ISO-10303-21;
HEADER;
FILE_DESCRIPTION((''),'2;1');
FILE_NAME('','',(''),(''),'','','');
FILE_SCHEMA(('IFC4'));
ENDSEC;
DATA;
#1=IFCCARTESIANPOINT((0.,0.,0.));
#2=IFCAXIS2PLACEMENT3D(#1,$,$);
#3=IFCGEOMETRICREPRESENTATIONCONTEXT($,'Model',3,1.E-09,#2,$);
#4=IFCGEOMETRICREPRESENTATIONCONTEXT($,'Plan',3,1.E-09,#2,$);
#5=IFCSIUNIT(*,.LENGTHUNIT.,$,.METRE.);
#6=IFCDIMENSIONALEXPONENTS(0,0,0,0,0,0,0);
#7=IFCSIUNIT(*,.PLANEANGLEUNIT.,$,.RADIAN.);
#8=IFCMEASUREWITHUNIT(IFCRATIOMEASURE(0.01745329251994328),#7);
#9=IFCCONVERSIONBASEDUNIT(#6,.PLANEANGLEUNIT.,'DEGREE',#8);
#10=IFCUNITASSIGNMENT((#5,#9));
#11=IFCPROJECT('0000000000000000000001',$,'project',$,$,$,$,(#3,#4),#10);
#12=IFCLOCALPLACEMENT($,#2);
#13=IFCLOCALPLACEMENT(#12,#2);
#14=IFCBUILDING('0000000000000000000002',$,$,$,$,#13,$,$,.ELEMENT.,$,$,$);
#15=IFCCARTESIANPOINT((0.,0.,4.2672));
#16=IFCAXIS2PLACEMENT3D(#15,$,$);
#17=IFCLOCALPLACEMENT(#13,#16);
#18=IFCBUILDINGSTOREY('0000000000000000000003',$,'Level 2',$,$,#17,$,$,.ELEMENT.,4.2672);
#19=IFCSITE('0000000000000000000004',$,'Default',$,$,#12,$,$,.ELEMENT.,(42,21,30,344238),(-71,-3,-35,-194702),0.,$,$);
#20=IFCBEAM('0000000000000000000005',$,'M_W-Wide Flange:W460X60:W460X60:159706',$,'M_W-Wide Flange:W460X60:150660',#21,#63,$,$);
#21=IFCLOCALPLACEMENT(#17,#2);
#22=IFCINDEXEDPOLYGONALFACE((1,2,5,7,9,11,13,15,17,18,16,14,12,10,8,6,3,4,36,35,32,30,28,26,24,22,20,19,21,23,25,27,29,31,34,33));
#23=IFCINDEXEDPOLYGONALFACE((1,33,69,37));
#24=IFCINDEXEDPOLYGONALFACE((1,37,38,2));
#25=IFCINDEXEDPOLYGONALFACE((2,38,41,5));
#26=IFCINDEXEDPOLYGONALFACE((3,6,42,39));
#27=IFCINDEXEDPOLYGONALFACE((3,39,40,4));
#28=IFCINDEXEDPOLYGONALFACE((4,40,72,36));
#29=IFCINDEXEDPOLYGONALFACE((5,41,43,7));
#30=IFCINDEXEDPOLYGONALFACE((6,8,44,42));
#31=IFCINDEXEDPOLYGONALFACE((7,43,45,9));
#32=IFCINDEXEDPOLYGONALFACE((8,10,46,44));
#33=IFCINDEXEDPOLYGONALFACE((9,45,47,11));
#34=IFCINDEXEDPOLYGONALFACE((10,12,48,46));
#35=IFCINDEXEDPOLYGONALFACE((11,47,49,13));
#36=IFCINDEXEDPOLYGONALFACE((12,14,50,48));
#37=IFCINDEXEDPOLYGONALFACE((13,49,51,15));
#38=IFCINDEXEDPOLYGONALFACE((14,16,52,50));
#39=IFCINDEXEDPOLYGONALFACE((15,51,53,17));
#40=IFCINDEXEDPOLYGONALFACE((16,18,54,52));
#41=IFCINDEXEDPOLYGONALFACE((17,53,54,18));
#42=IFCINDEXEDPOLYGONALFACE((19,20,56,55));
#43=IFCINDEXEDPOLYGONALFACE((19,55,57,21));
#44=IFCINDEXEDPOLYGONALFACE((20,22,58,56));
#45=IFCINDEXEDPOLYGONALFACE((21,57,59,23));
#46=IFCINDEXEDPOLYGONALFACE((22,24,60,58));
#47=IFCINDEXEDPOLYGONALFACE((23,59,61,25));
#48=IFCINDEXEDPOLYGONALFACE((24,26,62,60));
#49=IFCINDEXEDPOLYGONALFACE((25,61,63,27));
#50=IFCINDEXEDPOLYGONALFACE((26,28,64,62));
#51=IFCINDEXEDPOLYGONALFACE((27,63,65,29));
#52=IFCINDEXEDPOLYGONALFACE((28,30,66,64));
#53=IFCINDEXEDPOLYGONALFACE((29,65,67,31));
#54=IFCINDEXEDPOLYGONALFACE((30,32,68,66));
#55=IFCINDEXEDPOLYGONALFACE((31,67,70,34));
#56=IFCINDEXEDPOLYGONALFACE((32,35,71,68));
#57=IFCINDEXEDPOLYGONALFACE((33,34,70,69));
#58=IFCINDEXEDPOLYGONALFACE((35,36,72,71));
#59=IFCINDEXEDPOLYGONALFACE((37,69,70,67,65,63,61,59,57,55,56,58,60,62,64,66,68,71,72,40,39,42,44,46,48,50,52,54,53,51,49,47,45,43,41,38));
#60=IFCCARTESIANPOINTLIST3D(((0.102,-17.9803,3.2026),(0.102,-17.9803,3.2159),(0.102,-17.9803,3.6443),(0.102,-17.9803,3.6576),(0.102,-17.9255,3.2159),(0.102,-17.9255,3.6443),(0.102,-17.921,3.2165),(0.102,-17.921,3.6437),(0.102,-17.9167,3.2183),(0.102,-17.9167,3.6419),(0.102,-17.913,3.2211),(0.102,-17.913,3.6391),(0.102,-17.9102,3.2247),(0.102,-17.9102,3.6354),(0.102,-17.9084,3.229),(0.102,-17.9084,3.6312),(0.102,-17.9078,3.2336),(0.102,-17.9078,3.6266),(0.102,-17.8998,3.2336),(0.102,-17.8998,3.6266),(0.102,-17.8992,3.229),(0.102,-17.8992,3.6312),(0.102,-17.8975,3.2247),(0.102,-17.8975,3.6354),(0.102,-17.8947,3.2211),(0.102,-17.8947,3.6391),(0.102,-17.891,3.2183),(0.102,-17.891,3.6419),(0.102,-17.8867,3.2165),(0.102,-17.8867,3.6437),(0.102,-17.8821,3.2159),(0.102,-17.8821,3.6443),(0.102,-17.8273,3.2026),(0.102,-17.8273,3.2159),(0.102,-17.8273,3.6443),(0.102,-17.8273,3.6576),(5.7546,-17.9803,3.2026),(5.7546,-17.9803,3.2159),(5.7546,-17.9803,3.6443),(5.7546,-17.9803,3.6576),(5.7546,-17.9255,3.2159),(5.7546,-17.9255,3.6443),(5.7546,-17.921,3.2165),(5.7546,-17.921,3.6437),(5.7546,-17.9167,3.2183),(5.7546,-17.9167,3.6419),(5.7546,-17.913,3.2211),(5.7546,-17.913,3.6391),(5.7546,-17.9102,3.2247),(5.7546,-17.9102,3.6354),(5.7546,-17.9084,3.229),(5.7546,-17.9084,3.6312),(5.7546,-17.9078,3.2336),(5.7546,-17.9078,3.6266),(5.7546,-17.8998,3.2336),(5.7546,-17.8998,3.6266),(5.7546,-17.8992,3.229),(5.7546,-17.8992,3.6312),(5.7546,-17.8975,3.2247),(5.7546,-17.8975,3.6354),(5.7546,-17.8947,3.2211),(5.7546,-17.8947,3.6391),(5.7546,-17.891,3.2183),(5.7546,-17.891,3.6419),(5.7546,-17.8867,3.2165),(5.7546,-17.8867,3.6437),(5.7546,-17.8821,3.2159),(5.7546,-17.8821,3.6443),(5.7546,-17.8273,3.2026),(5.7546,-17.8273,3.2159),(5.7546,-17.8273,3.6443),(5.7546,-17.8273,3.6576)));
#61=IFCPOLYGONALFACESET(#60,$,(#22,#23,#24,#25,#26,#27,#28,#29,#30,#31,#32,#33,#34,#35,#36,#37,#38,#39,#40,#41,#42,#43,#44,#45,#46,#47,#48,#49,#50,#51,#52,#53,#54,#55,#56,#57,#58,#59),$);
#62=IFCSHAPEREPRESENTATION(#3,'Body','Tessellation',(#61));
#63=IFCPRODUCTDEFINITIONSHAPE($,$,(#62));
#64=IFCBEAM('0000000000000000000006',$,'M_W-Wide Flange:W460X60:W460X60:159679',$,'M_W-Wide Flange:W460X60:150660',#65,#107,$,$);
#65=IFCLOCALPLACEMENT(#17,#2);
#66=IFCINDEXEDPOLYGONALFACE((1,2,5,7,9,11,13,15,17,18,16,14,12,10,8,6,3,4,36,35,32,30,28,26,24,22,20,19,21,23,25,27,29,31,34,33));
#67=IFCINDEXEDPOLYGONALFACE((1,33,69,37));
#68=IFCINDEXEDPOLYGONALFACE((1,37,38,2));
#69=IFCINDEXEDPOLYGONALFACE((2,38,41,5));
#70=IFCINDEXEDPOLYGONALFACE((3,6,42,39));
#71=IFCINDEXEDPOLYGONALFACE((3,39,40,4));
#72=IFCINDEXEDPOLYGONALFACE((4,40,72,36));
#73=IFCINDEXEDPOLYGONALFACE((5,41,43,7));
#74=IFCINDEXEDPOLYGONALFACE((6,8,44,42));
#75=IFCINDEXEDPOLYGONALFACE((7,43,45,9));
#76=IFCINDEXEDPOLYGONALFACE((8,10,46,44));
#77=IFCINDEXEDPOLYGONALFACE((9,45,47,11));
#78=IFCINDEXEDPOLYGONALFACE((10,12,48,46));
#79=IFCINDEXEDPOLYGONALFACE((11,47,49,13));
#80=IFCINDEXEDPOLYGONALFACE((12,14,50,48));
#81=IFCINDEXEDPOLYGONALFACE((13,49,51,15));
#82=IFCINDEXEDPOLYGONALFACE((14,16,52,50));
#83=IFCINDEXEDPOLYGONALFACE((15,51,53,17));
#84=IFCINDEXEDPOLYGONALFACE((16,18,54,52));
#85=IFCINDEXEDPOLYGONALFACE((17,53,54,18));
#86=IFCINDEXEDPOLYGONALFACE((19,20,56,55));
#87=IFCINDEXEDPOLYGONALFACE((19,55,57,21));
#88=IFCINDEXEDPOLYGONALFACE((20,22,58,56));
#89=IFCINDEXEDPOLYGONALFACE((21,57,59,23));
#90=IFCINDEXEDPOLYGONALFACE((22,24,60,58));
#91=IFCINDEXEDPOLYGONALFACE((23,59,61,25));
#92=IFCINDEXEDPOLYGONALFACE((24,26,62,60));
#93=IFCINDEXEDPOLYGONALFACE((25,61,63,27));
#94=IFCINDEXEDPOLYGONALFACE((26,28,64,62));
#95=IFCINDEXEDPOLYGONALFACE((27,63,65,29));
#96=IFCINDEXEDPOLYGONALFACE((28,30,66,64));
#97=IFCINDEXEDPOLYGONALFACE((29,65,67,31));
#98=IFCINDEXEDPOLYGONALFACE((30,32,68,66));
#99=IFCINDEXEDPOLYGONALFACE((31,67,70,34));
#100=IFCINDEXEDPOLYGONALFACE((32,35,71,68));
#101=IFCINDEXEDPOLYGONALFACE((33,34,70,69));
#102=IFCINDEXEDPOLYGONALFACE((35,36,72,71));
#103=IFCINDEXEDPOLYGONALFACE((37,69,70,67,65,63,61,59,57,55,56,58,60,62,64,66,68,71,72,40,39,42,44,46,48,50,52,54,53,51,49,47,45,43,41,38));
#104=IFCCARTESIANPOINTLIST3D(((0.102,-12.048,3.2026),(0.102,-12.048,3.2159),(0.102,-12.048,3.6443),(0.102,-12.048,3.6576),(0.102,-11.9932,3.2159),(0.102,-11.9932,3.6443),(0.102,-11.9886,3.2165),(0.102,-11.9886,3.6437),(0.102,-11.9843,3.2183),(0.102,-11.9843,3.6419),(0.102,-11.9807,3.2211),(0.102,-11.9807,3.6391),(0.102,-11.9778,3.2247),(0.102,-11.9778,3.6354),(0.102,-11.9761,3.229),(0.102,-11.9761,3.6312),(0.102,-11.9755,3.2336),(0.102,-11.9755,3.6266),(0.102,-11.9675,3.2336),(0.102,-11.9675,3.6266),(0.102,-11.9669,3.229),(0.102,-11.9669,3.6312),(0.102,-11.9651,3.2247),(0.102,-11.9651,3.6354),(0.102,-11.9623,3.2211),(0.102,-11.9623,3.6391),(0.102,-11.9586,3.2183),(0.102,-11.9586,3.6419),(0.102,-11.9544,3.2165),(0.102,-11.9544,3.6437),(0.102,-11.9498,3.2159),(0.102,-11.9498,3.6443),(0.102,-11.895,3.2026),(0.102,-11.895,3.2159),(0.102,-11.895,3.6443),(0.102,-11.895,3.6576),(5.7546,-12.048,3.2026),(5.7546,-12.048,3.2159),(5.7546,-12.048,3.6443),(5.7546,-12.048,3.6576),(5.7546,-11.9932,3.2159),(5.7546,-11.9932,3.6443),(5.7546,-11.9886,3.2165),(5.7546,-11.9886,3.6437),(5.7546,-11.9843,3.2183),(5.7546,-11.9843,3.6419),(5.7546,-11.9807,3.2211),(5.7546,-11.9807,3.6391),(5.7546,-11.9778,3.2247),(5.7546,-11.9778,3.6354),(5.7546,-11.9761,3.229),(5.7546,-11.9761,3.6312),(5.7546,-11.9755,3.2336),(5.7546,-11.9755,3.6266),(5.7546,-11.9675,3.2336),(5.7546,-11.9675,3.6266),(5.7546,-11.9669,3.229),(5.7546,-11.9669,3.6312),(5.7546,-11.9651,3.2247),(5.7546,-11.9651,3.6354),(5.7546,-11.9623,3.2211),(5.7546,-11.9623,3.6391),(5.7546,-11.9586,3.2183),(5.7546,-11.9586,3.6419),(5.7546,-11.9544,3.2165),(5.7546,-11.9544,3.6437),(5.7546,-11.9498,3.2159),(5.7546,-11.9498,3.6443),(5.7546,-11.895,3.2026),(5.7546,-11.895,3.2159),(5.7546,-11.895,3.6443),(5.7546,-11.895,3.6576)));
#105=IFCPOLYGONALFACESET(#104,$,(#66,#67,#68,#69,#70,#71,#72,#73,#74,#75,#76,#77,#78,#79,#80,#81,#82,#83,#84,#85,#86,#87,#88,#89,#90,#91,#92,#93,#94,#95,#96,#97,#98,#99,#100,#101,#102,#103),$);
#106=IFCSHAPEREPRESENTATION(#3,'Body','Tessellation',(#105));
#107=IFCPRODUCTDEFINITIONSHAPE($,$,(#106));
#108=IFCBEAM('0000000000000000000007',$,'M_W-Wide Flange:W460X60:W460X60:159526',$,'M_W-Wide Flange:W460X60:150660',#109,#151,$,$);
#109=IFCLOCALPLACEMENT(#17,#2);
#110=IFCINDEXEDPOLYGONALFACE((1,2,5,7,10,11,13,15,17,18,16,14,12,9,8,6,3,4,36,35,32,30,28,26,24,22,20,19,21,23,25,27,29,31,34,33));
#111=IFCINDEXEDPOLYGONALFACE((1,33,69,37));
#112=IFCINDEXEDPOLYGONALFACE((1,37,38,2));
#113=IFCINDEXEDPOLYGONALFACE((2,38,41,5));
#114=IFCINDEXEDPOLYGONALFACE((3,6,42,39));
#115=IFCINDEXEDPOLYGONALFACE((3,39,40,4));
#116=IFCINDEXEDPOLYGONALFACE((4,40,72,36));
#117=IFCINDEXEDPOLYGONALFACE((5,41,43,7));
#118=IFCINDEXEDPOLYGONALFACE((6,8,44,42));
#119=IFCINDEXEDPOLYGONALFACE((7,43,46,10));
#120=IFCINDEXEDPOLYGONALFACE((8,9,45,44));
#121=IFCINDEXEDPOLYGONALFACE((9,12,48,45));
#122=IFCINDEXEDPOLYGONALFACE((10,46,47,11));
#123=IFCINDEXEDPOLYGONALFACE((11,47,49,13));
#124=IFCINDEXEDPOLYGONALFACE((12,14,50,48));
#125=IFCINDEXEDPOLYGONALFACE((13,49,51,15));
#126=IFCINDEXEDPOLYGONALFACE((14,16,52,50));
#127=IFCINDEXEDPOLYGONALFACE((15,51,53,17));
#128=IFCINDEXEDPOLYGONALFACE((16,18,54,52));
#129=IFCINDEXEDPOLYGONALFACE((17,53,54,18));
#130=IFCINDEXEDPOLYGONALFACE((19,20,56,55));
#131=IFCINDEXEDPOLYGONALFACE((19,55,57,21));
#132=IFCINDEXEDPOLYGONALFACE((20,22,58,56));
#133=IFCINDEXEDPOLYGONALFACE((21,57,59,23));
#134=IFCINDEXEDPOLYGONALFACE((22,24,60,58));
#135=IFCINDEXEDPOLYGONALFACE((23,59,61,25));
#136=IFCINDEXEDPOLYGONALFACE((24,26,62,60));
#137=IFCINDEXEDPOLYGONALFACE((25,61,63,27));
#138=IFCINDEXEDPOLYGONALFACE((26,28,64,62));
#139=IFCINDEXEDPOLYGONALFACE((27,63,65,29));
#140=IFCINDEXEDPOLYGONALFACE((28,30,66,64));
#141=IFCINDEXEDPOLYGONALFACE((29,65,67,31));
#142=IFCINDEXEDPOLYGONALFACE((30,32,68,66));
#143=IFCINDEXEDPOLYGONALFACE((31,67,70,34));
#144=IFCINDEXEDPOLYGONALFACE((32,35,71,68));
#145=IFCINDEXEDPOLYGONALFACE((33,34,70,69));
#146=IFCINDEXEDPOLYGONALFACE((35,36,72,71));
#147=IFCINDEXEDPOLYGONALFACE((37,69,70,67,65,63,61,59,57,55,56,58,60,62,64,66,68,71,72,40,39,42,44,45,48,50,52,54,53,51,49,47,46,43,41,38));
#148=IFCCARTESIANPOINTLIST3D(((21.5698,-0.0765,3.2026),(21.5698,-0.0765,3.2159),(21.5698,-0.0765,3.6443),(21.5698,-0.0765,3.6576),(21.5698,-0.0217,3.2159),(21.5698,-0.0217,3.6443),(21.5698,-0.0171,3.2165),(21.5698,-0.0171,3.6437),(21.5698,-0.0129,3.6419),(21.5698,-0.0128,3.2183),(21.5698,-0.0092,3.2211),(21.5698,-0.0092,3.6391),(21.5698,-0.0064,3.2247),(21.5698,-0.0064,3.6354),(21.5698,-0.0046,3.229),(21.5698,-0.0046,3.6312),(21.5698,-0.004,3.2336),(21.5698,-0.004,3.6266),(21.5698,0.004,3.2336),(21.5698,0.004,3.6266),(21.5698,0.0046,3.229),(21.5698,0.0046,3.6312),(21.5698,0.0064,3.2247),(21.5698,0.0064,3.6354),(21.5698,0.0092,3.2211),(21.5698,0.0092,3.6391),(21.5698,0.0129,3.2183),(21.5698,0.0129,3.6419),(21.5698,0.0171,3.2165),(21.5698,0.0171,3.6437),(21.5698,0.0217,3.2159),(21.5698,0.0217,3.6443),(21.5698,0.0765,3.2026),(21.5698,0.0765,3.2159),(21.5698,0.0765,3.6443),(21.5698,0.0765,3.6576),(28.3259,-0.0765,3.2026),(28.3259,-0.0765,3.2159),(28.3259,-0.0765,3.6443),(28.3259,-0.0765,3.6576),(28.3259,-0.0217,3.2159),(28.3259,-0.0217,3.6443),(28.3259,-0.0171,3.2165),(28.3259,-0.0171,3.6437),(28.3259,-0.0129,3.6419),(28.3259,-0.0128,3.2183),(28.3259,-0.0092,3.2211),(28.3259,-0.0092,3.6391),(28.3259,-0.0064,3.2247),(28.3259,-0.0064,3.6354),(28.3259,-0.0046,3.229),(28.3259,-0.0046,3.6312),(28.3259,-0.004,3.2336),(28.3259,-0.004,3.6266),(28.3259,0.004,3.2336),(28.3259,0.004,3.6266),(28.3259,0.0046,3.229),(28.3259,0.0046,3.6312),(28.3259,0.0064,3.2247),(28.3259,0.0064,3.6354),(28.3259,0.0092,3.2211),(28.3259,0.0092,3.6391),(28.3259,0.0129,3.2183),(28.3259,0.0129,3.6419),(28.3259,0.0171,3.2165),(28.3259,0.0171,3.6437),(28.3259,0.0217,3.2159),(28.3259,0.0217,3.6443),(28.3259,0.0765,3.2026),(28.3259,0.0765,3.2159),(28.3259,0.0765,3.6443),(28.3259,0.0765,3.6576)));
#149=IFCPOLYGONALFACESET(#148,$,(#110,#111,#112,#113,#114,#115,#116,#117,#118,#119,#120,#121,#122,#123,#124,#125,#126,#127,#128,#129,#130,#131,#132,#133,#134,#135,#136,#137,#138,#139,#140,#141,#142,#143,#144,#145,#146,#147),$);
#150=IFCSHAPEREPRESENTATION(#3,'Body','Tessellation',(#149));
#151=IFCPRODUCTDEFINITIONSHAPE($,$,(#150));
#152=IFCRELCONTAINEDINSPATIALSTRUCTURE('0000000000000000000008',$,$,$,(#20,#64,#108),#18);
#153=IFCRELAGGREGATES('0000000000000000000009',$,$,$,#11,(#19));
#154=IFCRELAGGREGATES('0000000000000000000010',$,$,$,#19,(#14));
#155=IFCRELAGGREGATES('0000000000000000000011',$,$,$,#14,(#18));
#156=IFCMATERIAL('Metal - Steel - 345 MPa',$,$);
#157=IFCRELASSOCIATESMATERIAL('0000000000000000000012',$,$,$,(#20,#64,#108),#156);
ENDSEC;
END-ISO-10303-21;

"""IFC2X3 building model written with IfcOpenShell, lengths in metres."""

from ifc_helpers import new_model, entity, si_unit, converted_unit, frame, frame_2d, origin, place, context, project, spatial, polyline, circle_curve, parameter, trimmed, segment, composite_curve, outline, extrude, material, element, save


model = new_model("IFC2X3")

# Units and contexts
model_context = context("Model", 3, precision=1e-09, world=origin())
plan_context = context("Plan", 3, precision=1e-09, world=origin())
ifc_project = project(units=[si_unit("LENGTHUNIT", "METRE"), converted_unit("PLANEANGLEUNIT", "DEGREE", entity("IfcRatioMeasure", 0.01745329251994328), si_unit("PLANEANGLEUNIT", "RADIAN"), dimensions=[0, 0, 0, 0, 0, 0, 0])], contexts=[model_context, plan_context])

# Site, building, storey
site_placement = place(None, origin())
site = spatial("IfcSite", under=ifc_project, at=site_placement, Name="Default", CompositionType="ELEMENT", RefLatitude=(42, 21, 30, 344238), RefLongitude=(-71, -3, -35, -194702), RefElevation=0.0)
building_placement = place(site_placement, origin())
building = spatial("IfcBuilding", under=site, at=building_placement, CompositionType="ELEMENT")
storey_placement = place(building_placement, frame((0.0, 0.0, 4.2672)))
storey = spatial("IfcBuildingStorey", under=building, at=storey_placement, Name="Level 2", CompositionType="ELEMENT", Elevation=4.2672)

# Shared definitions
ifc_material = material(Name="Metal - Steel - 345 MPa")

# Beams
beam_1_placement = place(storey_placement, frame((0.0, -17.9038, 3.6576), z_axis=(0.0, 0.0, 1.0), x_axis=(0.0, -1.0, 0.0)))
element("IfcBeam", 1, at=beam_1_placement, inside=storey, material=ifc_material, Name="M_W-Wide Flange:W460X60:W460X60:159706", ObjectType="M_W-Wide Flange:W460X60:150660", context=model_context, shape_type="SweptSolid", body=[
    extrude(outline(composite_curve([segment(polyline([(-0.0765, -0.2142), (-0.0765, -0.2275)]), True, "CONTINUOUS"), segment(polyline([(-0.0765, -0.2275), (0.0765, -0.2275)]), True, "CONTINUOUS"), segment(polyline([(0.0765, -0.2275), (0.0765, -0.2142)]), True, "CONTINUOUS"), segment(polyline([(0.0765, -0.2142), (0.0217, -0.2142)]), True, "CONTINUOUS"), segment(trimmed(circle_curve(frame_2d((0.0217, -0.1965), x_axis=(1.0, 0.0)), 0.0177), [parameter(180.0)], [parameter(270.0)], True, "PARAMETER"), False, "CONTINUOUS"), segment(polyline([(0.004, -0.1965), (0.004, 0.1965)]), True, "CONTINUOUS"), segment(trimmed(circle_curve(frame_2d((0.0217, 0.1965), x_axis=(1.0, 0.0)), 0.0177), [parameter(90.0)], [parameter(180.0)], True, "PARAMETER"), False, "CONTINUOUS"), segment(polyline([(0.0217, 0.2142), (0.0765, 0.2142)]), True, "CONTINUOUS"), segment(polyline([(0.0765, 0.2142), (0.0765, 0.2275)]), True, "CONTINUOUS"), segment(polyline([(0.0765, 0.2275), (-0.0765, 0.2275)]), True, "CONTINUOUS"), segment(polyline([(-0.0765, 0.2275), (-0.0765, 0.2142)]), True, "CONTINUOUS"), segment(polyline([(-0.0765, 0.2142), (-0.0217, 0.2142)]), True, "CONTINUOUS"), segment(trimmed(circle_curve(frame_2d((-0.0217, 0.1965), x_axis=(1.0, 0.0)), 0.0177), [parameter(360.0)], [parameter(90.0)], True, "PARAMETER"), False, "CONTINUOUS"), segment(polyline([(-0.004, 0.1965), (-0.004, -0.1965)]), True, "CONTINUOUS"), segment(trimmed(circle_curve(frame_2d((-0.0217, -0.1965), x_axis=(1.0, 0.0)), 0.0177), [parameter(270.0)], [parameter(0.0)], True, "PARAMETER"), False, "CONTINUOUS"), segment(polyline([(-0.0217, -0.2142), (-0.0765, -0.2142)]), True, "CONTINUOUS")], self_intersect=False)), frame((0.0, 0.102, -0.2275), z_axis=(0.0, -1.0, 0.0), x_axis=(1.0, 0.0, 0.0)), (0.0, 0.0, -1.0), 5.6526),
])
beam_2_placement = place(storey_placement, frame((5.8566, -11.9715, 3.6576), z_axis=(0.0, 0.0, 1.0), x_axis=(0.0, 1.0, 0.0)))
element("IfcBeam", 2, at=beam_2_placement, inside=storey, material=ifc_material, Name="M_W-Wide Flange:W460X60:W460X60:159679", ObjectType="M_W-Wide Flange:W460X60:150660", context=model_context, shape_type="SweptSolid", body=[
    extrude(outline(composite_curve([segment(polyline([(0.2142, -0.0765), (0.2275, -0.0765)]), True, "CONTINUOUS"), segment(polyline([(0.2275, -0.0765), (0.2275, 0.0765)]), True, "CONTINUOUS"), segment(polyline([(0.2275, 0.0765), (0.2142, 0.0765)]), True, "CONTINUOUS"), segment(polyline([(0.2142, 0.0765), (0.2142, 0.0217)]), True, "CONTINUOUS"), segment(trimmed(circle_curve(frame_2d((0.1965, 0.0217), x_axis=(0.0, 1.0)), 0.0177), [parameter(180.0)], [parameter(270.0)], True, "PARAMETER"), False, "CONTINUOUS"), segment(polyline([(0.1965, 0.004), (-0.1965, 0.004)]), True, "CONTINUOUS"), segment(trimmed(circle_curve(frame_2d((-0.1965, 0.0217), x_axis=(0.0, 1.0)), 0.0177), [parameter(90.0)], [parameter(180.0)], True, "PARAMETER"), False, "CONTINUOUS"), segment(polyline([(-0.2142, 0.0217), (-0.2142, 0.0765)]), True, "CONTINUOUS"), segment(polyline([(-0.2142, 0.0765), (-0.2275, 0.0765)]), True, "CONTINUOUS"), segment(polyline([(-0.2275, 0.0765), (-0.2275, -0.0765)]), True, "CONTINUOUS"), segment(polyline([(-0.2275, -0.0765), (-0.2142, -0.0765)]), True, "CONTINUOUS"), segment(polyline([(-0.2142, -0.0765), (-0.2142, -0.0217)]), True, "CONTINUOUS"), segment(trimmed(circle_curve(frame_2d((-0.1965, -0.0217), x_axis=(0.0, 1.0)), 0.0177), [parameter(360.0)], [parameter(90.0)], True, "PARAMETER"), False, "CONTINUOUS"), segment(polyline([(-0.1965, -0.004), (0.1965, -0.004)]), True, "CONTINUOUS"), segment(trimmed(circle_curve(frame_2d((0.1965, -0.0217), x_axis=(0.0, 1.0)), 0.0177), [parameter(270.0)], [parameter(0.0)], True, "PARAMETER"), False, "CONTINUOUS"), segment(polyline([(0.2142, -0.0217), (0.2142, -0.0765)]), True, "CONTINUOUS")], self_intersect=False)), frame((0.0, 5.7546, -0.2275), z_axis=(0.0, -1.0, 0.0), x_axis=(0.0, 0.0, -1.0)), (0.0, 0.0, 1.0), 5.6526),
])
beam_3_placement = place(storey_placement, frame((21.4678, 0.0, 3.6576), z_axis=(0.0, 0.0, 1.0), x_axis=(0.0, -1.0, 0.0)))
element("IfcBeam", 3, at=beam_3_placement, inside=storey, material=ifc_material, Name="M_W-Wide Flange:W460X60:W460X60:159526", ObjectType="M_W-Wide Flange:W460X60:150660", context=model_context, shape_type="SweptSolid", body=[
    extrude(outline(composite_curve([segment(polyline([(-0.0765, -0.2142), (-0.0765, -0.2275)]), True, "CONTINUOUS"), segment(polyline([(-0.0765, -0.2275), (0.0765, -0.2275)]), True, "CONTINUOUS"), segment(polyline([(0.0765, -0.2275), (0.0765, -0.2142)]), True, "CONTINUOUS"), segment(polyline([(0.0765, -0.2142), (0.0217, -0.2142)]), True, "CONTINUOUS"), segment(trimmed(circle_curve(frame_2d((0.0217, -0.1965), x_axis=(0.0, -1.0)), 0.0177), [parameter(270.0)], [parameter(360.0)], True, "PARAMETER"), False, "CONTINUOUS"), segment(polyline([(0.004, -0.1965), (0.004, 0.1965)]), True, "CONTINUOUS"), segment(trimmed(circle_curve(frame_2d((0.0217, 0.1965), x_axis=(-1.0, 0.0)), 0.0177), [parameter(270.0)], [parameter(360.0)], True, "PARAMETER"), False, "CONTINUOUS"), segment(polyline([(0.0217, 0.2142), (0.0765, 0.2142)]), True, "CONTINUOUS"), segment(polyline([(0.0765, 0.2142), (0.0765, 0.2275)]), True, "CONTINUOUS"), segment(polyline([(0.0765, 0.2275), (-0.0765, 0.2275)]), True, "CONTINUOUS"), segment(polyline([(-0.0765, 0.2275), (-0.0765, 0.2142)]), True, "CONTINUOUS"), segment(polyline([(-0.0765, 0.2142), (-0.0217, 0.2142)]), True, "CONTINUOUS"), segment(trimmed(circle_curve(frame_2d((-0.0217, 0.1965), x_axis=(0.0, 1.0)), 0.0177), [parameter(270.0)], [parameter(360.0)], True, "PARAMETER"), False, "CONTINUOUS"), segment(polyline([(-0.004, 0.1965), (-0.004, -0.1965)]), True, "CONTINUOUS"), segment(trimmed(circle_curve(frame_2d((-0.0217, -0.1965), x_axis=(1.0, 0.0)), 0.0177), [parameter(270.0)], [parameter(0.0)], True, "PARAMETER"), False, "CONTINUOUS"), segment(polyline([(-0.0217, -0.2142), (-0.0765, -0.2142)]), True, "CONTINUOUS")], self_intersect=False)), frame((0.0, 0.102, -0.2275), z_axis=(0.0, -1.0, 0.0), x_axis=(1.0, 0.0, 0.0)), (0.0, 0.0, -1.0), 6.7561),
])

save(model, "model.ifc")
